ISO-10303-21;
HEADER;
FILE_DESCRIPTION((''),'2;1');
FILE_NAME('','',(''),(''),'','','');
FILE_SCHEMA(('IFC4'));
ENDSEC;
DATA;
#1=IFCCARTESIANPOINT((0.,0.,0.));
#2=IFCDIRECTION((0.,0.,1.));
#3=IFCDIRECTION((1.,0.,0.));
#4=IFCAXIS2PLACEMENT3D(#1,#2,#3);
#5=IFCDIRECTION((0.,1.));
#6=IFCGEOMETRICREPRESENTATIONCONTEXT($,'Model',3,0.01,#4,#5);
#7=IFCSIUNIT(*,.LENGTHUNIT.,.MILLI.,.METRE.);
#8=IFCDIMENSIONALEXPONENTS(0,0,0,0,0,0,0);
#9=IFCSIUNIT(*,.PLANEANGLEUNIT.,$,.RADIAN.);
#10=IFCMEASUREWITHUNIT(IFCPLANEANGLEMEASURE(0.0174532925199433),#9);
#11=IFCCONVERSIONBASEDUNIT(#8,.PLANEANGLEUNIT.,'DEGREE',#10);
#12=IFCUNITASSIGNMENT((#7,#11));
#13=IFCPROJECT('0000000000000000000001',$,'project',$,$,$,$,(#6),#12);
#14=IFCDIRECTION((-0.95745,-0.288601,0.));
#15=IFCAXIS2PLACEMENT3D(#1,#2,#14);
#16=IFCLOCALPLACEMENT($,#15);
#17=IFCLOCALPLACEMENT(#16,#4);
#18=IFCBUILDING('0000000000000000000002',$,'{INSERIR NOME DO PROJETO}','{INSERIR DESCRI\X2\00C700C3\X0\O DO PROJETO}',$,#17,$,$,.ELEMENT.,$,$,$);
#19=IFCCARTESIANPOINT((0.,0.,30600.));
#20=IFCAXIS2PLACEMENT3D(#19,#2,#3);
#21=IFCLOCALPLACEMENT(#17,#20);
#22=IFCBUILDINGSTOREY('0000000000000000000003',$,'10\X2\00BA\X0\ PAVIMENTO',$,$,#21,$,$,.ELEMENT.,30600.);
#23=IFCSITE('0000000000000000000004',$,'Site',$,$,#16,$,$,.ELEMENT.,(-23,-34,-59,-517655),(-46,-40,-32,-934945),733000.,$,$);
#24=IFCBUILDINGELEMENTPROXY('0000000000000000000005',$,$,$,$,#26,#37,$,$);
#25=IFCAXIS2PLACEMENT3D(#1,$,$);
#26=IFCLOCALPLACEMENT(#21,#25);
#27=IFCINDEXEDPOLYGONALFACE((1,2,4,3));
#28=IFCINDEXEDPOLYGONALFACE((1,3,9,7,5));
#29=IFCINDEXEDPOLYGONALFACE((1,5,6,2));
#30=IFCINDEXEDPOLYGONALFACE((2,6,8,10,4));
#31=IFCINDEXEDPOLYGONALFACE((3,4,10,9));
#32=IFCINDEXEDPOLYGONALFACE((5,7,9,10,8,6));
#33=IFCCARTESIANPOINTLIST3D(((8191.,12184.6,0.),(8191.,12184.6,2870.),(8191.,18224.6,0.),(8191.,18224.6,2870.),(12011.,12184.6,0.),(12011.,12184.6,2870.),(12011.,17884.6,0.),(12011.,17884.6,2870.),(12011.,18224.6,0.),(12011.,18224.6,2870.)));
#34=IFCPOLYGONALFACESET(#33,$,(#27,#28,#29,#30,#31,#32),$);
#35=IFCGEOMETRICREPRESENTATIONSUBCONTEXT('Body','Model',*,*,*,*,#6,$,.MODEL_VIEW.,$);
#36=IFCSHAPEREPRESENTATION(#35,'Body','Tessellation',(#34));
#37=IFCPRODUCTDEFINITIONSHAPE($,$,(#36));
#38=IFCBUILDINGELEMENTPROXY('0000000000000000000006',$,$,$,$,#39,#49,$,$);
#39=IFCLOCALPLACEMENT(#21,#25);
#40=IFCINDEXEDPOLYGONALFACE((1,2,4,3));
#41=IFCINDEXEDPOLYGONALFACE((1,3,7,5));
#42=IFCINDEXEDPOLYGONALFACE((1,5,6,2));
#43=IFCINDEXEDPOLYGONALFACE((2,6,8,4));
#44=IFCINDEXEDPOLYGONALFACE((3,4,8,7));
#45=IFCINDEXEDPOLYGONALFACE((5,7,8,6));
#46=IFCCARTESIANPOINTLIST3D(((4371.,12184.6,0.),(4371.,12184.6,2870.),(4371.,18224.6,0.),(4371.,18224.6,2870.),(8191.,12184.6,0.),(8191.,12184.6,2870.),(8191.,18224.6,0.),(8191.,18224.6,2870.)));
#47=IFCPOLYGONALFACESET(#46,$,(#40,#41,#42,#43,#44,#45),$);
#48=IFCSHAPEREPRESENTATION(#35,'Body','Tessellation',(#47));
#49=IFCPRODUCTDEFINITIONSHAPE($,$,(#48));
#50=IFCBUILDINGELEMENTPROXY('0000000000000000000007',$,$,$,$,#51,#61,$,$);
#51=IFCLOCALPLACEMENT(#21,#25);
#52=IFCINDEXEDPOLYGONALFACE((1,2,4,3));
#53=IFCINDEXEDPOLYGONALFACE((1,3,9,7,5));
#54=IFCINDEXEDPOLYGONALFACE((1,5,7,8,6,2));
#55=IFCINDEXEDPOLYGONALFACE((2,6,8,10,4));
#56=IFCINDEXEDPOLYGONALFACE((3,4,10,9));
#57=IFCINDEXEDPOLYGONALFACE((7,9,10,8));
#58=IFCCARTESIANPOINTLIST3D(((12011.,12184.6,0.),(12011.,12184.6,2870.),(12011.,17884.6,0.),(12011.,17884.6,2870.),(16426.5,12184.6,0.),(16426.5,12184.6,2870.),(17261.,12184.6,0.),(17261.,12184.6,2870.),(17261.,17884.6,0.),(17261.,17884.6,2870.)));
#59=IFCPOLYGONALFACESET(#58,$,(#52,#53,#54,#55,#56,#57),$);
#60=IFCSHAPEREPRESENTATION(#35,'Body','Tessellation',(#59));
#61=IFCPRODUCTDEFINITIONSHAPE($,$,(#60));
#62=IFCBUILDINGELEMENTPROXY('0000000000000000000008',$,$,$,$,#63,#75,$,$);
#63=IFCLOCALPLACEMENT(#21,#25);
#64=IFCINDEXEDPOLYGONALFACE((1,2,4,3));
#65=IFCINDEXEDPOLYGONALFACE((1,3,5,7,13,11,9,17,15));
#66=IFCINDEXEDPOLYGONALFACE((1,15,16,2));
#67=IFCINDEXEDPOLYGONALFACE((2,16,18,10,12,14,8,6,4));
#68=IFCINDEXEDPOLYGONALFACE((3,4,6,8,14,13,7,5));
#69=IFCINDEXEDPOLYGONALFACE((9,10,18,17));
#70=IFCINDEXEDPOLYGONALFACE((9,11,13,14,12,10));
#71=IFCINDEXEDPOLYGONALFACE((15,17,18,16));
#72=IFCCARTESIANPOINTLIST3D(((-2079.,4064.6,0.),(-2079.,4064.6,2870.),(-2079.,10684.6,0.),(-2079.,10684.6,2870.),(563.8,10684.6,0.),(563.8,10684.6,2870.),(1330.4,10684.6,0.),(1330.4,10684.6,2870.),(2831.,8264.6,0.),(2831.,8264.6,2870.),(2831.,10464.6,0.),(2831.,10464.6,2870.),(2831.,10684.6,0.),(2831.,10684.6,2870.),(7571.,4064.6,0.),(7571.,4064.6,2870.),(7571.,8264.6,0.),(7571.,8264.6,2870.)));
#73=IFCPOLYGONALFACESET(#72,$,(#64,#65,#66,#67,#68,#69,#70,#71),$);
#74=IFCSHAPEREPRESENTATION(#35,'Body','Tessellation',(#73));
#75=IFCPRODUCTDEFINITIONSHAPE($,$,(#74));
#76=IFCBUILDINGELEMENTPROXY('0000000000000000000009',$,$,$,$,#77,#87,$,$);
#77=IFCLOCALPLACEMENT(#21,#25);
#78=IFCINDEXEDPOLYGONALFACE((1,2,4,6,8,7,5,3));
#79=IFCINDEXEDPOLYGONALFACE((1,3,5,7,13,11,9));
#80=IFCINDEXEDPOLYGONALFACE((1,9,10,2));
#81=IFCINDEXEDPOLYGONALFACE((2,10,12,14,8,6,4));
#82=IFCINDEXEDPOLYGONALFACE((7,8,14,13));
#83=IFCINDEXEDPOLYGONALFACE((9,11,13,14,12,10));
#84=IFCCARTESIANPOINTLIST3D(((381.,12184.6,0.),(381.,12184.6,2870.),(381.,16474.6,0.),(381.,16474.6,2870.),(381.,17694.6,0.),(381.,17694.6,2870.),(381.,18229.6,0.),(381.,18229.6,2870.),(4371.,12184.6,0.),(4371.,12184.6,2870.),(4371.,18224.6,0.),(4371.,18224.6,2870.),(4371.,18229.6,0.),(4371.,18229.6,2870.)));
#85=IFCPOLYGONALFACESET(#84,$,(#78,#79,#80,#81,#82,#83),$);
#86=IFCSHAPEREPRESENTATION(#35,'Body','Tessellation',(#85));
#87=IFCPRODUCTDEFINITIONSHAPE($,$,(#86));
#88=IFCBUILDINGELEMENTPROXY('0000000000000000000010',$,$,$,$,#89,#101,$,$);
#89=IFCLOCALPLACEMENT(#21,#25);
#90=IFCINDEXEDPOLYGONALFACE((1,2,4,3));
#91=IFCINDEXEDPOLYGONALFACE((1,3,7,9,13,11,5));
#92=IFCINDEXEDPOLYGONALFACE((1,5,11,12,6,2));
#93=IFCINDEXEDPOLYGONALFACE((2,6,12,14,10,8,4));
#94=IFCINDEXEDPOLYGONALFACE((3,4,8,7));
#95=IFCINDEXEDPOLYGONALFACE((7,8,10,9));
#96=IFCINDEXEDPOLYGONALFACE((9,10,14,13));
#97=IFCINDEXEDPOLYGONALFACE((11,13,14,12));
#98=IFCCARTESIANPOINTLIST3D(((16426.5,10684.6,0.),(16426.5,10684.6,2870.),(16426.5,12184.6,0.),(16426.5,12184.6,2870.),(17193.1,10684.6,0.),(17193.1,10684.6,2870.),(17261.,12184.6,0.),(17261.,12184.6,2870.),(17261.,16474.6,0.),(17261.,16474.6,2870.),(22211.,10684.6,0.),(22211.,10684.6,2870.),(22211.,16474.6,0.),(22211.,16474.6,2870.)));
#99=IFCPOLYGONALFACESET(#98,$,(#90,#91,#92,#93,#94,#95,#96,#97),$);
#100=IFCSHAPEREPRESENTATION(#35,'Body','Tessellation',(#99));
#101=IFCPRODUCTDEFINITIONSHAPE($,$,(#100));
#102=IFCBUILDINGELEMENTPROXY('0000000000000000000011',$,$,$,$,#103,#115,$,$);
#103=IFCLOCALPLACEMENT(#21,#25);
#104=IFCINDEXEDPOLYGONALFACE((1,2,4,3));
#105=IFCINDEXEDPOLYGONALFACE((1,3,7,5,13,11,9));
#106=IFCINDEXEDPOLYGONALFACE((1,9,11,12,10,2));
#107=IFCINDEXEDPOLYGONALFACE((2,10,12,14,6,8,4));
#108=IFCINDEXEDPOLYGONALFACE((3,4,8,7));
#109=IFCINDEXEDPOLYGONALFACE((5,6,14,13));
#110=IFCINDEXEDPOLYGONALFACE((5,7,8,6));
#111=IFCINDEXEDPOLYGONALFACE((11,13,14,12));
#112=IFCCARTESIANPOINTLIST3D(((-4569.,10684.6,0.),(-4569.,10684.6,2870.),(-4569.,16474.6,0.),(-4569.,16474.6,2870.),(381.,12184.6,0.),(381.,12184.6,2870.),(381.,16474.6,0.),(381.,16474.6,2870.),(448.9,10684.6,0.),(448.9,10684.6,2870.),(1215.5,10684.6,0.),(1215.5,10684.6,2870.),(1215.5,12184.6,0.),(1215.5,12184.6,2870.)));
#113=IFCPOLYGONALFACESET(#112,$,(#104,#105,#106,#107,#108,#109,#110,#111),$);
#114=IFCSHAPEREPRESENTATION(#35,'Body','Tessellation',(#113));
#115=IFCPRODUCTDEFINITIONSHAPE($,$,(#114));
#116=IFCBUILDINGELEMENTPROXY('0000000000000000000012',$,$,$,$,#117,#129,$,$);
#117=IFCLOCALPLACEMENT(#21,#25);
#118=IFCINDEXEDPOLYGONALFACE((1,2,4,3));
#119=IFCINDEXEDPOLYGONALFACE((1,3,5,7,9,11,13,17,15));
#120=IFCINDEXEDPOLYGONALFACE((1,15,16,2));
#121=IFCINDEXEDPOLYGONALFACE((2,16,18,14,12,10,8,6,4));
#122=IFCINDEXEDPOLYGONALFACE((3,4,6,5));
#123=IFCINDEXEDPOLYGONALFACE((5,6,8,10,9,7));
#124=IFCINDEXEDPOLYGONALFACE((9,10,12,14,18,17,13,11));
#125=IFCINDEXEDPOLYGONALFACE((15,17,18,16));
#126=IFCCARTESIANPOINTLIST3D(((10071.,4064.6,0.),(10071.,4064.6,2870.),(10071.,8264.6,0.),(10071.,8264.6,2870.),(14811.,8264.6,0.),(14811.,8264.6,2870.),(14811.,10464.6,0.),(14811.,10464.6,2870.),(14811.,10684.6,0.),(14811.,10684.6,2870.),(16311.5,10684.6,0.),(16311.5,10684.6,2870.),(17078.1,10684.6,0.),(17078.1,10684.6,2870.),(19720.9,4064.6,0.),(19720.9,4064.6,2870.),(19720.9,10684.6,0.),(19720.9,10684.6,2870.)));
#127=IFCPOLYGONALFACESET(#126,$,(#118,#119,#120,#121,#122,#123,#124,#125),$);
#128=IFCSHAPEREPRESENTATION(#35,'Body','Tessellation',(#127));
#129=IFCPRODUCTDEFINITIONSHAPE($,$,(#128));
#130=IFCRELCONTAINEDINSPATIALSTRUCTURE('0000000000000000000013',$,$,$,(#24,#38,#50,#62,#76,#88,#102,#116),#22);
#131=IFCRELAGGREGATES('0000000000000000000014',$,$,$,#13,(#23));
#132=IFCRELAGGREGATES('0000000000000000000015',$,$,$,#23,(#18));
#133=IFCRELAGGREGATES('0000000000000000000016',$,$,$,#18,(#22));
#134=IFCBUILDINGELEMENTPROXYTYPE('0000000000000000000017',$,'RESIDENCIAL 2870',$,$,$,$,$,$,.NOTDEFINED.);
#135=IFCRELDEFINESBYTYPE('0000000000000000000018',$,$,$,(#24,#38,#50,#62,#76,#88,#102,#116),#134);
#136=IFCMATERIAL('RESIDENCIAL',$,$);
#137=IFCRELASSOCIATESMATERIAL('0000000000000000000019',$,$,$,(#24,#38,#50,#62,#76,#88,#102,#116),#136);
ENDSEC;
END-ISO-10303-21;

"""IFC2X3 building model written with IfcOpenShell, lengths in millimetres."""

from ifc_helpers import new_model, entity, si_unit, converted_unit, direction, frame, origin_with_axes, place, context, subcontext, project, spatial, polyline, outline, extrude, material, type_object, element, save


model = new_model("IFC2X3")

# Units and contexts
model_context = context("Model", 3, precision=0.01, world=origin_with_axes(), true_north=direction((0.0, 1.0)))
body_context = subcontext(model_context, "Body", "Model", "MODEL_VIEW")
ifc_project = project(units=[si_unit("LENGTHUNIT", "METRE", prefix="MILLI"), converted_unit("PLANEANGLEUNIT", "DEGREE", entity("IfcPlaneAngleMeasure", 0.0174532925199433), si_unit("PLANEANGLEUNIT", "RADIAN"), dimensions=[0, 0, 0, 0, 0, 0, 0])], contexts=[model_context])

# Site, building, storey
site_placement = place(None, frame((0.0, 0.0, 0.0), z_axis=(0.0, 0.0, 1.0), x_axis=(-0.95745, -0.288601, 0.0)))
site = spatial("IfcSite", under=ifc_project, at=site_placement, Name="Site", CompositionType="ELEMENT", RefLatitude=(-23, -34, -59, -517655), RefLongitude=(-46, -40, -32, -934945), RefElevation=733000.0)
building_placement = place(site_placement, origin_with_axes())
building = spatial("IfcBuilding", under=site, at=building_placement, Name="{INSERIR NOME DO PROJETO}", Description="{INSERIR DESCRIÇÃO DO PROJETO}", CompositionType="ELEMENT")
storey_placement = place(building_placement, frame((0.0, 0.0, 30600.0), z_axis=(0.0, 0.0, 1.0), x_axis=(1.0, 0.0, 0.0)))
storey = spatial("IfcBuildingStorey", under=building, at=storey_placement, Name="10º PAVIMENTO", CompositionType="ELEMENT", Elevation=30600.0)

# Building element proxies
ifc_material_1 = material(Name="RESIDENCIAL")
building_element_proxy_type_1 = type_object("IfcBuildingElementProxyType", Name="RESIDENCIAL 2870", PredefinedType="NOTDEFINED")
proxy_1_placement = place(storey_placement, frame((8191.0, 18224.6, 0.0), z_axis=(0.0, 0.0, 1.0), x_axis=(1.0, 0.0, 0.0)))
element("IfcBuildingElementProxy", 1, at=proxy_1_placement, inside=storey, type_object=building_element_proxy_type_1, material=ifc_material_1, context=body_context, shape_type="SweptSolid", body=[
    extrude(outline(polyline([(0.0, 0.0), (0.0, -6040.0), (3820.0, -6040.0), (3820.0, -340.0), (3820.0, 0.0), (0.0, 0.0)])), origin_with_axes(), (0.0, 0.0, 1.0), 2870.0),
])
proxy_2_placement = place(storey_placement, frame((4371.0, 18224.6, 0.0), z_axis=(0.0, 0.0, 1.0), x_axis=(1.0, 0.0, 0.0)))
element("IfcBuildingElementProxy", 2, at=proxy_2_placement, inside=storey, type_object=building_element_proxy_type_1, material=ifc_material_1, context=body_context, shape_type="SweptSolid", body=[
    extrude(outline(polyline([(0.0, 0.0), (0.0, -6040.0), (3820.0, -6040.0), (3820.0, 0.0), (0.0, 0.0)])), origin_with_axes(), (0.0, 0.0, 1.0), 2870.0),
])
proxy_3_placement = place(storey_placement, frame((12011.0, 12184.6, 0.0), z_axis=(0.0, 0.0, 1.0), x_axis=(1.0, 0.0, 0.0)))
element("IfcBuildingElementProxy", 3, at=proxy_3_placement, inside=storey, type_object=building_element_proxy_type_1, material=ifc_material_1, context=body_context, shape_type="SweptSolid", body=[
    extrude(outline(polyline([(0.0, 0.0), (4415.5, 0.0), (5250.0, 0.0), (5250.0, 5700.0), (0.0, 5700.0), (0.0, 0.0)])), origin_with_axes(), (0.0, 0.0, 1.0), 2870.0),
])
proxy_4_placement = place(storey_placement, frame((-2079.0, 4064.6, 0.0), z_axis=(0.0, 0.0, 1.0), x_axis=(1.0, 0.0, 0.0)))
element("IfcBuildingElementProxy", 4, at=proxy_4_placement, inside=storey, type_object=building_element_proxy_type_1, material=ifc_material_1, context=body_context, shape_type="SweptSolid", body=[
    extrude(outline(polyline([(0.0, 0.0), (9650.0, 0.0), (9650.0, 4200.0), (4910.0, 4200.0), (4910.0, 6400.0), (4910.0, 6620.0), (3409.4, 6620.0), (2642.8, 6620.0), (0.0, 6620.0), (0.0, 0.0)])), origin_with_axes(), (0.0, 0.0, 1.0), 2870.0),
])
proxy_5_placement = place(storey_placement, frame((381.0, 16474.6, 0.0), z_axis=(0.0, 0.0, 1.0), x_axis=(1.0, 0.0, 0.0)))
element("IfcBuildingElementProxy", 5, at=proxy_5_placement, inside=storey, type_object=building_element_proxy_type_1, material=ifc_material_1, context=body_context, shape_type="SweptSolid", body=[
    extrude(outline(polyline([(0.0, 0.0), (0.0, -4290.0), (3990.0, -4290.0), (3990.0, 1750.0), (3990.0, 1755.0), (0.0, 1755.0), (0.0, 1220.0), (0.0, 0.0)])), origin_with_axes(), (0.0, 0.0, 1.0), 2870.0),
])
proxy_6_placement = place(storey_placement, frame((17261.0, 12184.6, 0.0), z_axis=(0.0, 0.0, 1.0), x_axis=(1.0, 0.0, 0.0)))
element("IfcBuildingElementProxy", 6, at=proxy_6_placement, inside=storey, type_object=building_element_proxy_type_1, material=ifc_material_1, context=body_context, shape_type="SweptSolid", body=[
    extrude(outline(polyline([(0.0, 0.0), (-834.5, 0.0), (-834.5, -1500.0), (-67.9, -1500.0), (4950.0, -1500.0), (4950.0, 4290.0), (0.0, 4290.0), (0.0, 0.0)])), origin_with_axes(), (0.0, 0.0, 1.0), 2870.0),
])
proxy_7_placement = place(storey_placement, frame((-4569.0, 16474.6, 0.0), z_axis=(0.0, 0.0, 1.0), x_axis=(1.0, 0.0, 0.0)))
element("IfcBuildingElementProxy", 7, at=proxy_7_placement, inside=storey, type_object=building_element_proxy_type_1, material=ifc_material_1, context=body_context, shape_type="SweptSolid", body=[
    extrude(outline(polyline([(0.0, 0.0), (0.0, -5790.0), (5017.9, -5790.0), (5784.5, -5790.0), (5784.5, -4290.0), (4950.0, -4290.0), (4950.0, 0.0), (0.0, 0.0)])), origin_with_axes(), (0.0, 0.0, 1.0), 2870.0),
])
proxy_8_placement = place(storey_placement, frame((19720.9, 4064.6, 0.0), z_axis=(0.0, 0.0, 1.0), x_axis=(1.0, 0.0, 0.0)))
element("IfcBuildingElementProxy", 8, at=proxy_8_placement, inside=storey, type_object=building_element_proxy_type_1, material=ifc_material_1, context=body_context, shape_type="SweptSolid", body=[
    extrude(outline(polyline([(0.0, 0.0), (0.0, 6620.0), (-2642.8, 6620.0), (-3409.4, 6620.0), (-4910.0, 6620.0), (-4910.0, 6400.0), (-4910.0, 4200.0), (-9650.0, 4200.0), (-9650.0, 0.0), (0.0, 0.0)])), origin_with_axes(), (0.0, 0.0, 1.0), 2870.0),
])

save(model, "model.ifc")
